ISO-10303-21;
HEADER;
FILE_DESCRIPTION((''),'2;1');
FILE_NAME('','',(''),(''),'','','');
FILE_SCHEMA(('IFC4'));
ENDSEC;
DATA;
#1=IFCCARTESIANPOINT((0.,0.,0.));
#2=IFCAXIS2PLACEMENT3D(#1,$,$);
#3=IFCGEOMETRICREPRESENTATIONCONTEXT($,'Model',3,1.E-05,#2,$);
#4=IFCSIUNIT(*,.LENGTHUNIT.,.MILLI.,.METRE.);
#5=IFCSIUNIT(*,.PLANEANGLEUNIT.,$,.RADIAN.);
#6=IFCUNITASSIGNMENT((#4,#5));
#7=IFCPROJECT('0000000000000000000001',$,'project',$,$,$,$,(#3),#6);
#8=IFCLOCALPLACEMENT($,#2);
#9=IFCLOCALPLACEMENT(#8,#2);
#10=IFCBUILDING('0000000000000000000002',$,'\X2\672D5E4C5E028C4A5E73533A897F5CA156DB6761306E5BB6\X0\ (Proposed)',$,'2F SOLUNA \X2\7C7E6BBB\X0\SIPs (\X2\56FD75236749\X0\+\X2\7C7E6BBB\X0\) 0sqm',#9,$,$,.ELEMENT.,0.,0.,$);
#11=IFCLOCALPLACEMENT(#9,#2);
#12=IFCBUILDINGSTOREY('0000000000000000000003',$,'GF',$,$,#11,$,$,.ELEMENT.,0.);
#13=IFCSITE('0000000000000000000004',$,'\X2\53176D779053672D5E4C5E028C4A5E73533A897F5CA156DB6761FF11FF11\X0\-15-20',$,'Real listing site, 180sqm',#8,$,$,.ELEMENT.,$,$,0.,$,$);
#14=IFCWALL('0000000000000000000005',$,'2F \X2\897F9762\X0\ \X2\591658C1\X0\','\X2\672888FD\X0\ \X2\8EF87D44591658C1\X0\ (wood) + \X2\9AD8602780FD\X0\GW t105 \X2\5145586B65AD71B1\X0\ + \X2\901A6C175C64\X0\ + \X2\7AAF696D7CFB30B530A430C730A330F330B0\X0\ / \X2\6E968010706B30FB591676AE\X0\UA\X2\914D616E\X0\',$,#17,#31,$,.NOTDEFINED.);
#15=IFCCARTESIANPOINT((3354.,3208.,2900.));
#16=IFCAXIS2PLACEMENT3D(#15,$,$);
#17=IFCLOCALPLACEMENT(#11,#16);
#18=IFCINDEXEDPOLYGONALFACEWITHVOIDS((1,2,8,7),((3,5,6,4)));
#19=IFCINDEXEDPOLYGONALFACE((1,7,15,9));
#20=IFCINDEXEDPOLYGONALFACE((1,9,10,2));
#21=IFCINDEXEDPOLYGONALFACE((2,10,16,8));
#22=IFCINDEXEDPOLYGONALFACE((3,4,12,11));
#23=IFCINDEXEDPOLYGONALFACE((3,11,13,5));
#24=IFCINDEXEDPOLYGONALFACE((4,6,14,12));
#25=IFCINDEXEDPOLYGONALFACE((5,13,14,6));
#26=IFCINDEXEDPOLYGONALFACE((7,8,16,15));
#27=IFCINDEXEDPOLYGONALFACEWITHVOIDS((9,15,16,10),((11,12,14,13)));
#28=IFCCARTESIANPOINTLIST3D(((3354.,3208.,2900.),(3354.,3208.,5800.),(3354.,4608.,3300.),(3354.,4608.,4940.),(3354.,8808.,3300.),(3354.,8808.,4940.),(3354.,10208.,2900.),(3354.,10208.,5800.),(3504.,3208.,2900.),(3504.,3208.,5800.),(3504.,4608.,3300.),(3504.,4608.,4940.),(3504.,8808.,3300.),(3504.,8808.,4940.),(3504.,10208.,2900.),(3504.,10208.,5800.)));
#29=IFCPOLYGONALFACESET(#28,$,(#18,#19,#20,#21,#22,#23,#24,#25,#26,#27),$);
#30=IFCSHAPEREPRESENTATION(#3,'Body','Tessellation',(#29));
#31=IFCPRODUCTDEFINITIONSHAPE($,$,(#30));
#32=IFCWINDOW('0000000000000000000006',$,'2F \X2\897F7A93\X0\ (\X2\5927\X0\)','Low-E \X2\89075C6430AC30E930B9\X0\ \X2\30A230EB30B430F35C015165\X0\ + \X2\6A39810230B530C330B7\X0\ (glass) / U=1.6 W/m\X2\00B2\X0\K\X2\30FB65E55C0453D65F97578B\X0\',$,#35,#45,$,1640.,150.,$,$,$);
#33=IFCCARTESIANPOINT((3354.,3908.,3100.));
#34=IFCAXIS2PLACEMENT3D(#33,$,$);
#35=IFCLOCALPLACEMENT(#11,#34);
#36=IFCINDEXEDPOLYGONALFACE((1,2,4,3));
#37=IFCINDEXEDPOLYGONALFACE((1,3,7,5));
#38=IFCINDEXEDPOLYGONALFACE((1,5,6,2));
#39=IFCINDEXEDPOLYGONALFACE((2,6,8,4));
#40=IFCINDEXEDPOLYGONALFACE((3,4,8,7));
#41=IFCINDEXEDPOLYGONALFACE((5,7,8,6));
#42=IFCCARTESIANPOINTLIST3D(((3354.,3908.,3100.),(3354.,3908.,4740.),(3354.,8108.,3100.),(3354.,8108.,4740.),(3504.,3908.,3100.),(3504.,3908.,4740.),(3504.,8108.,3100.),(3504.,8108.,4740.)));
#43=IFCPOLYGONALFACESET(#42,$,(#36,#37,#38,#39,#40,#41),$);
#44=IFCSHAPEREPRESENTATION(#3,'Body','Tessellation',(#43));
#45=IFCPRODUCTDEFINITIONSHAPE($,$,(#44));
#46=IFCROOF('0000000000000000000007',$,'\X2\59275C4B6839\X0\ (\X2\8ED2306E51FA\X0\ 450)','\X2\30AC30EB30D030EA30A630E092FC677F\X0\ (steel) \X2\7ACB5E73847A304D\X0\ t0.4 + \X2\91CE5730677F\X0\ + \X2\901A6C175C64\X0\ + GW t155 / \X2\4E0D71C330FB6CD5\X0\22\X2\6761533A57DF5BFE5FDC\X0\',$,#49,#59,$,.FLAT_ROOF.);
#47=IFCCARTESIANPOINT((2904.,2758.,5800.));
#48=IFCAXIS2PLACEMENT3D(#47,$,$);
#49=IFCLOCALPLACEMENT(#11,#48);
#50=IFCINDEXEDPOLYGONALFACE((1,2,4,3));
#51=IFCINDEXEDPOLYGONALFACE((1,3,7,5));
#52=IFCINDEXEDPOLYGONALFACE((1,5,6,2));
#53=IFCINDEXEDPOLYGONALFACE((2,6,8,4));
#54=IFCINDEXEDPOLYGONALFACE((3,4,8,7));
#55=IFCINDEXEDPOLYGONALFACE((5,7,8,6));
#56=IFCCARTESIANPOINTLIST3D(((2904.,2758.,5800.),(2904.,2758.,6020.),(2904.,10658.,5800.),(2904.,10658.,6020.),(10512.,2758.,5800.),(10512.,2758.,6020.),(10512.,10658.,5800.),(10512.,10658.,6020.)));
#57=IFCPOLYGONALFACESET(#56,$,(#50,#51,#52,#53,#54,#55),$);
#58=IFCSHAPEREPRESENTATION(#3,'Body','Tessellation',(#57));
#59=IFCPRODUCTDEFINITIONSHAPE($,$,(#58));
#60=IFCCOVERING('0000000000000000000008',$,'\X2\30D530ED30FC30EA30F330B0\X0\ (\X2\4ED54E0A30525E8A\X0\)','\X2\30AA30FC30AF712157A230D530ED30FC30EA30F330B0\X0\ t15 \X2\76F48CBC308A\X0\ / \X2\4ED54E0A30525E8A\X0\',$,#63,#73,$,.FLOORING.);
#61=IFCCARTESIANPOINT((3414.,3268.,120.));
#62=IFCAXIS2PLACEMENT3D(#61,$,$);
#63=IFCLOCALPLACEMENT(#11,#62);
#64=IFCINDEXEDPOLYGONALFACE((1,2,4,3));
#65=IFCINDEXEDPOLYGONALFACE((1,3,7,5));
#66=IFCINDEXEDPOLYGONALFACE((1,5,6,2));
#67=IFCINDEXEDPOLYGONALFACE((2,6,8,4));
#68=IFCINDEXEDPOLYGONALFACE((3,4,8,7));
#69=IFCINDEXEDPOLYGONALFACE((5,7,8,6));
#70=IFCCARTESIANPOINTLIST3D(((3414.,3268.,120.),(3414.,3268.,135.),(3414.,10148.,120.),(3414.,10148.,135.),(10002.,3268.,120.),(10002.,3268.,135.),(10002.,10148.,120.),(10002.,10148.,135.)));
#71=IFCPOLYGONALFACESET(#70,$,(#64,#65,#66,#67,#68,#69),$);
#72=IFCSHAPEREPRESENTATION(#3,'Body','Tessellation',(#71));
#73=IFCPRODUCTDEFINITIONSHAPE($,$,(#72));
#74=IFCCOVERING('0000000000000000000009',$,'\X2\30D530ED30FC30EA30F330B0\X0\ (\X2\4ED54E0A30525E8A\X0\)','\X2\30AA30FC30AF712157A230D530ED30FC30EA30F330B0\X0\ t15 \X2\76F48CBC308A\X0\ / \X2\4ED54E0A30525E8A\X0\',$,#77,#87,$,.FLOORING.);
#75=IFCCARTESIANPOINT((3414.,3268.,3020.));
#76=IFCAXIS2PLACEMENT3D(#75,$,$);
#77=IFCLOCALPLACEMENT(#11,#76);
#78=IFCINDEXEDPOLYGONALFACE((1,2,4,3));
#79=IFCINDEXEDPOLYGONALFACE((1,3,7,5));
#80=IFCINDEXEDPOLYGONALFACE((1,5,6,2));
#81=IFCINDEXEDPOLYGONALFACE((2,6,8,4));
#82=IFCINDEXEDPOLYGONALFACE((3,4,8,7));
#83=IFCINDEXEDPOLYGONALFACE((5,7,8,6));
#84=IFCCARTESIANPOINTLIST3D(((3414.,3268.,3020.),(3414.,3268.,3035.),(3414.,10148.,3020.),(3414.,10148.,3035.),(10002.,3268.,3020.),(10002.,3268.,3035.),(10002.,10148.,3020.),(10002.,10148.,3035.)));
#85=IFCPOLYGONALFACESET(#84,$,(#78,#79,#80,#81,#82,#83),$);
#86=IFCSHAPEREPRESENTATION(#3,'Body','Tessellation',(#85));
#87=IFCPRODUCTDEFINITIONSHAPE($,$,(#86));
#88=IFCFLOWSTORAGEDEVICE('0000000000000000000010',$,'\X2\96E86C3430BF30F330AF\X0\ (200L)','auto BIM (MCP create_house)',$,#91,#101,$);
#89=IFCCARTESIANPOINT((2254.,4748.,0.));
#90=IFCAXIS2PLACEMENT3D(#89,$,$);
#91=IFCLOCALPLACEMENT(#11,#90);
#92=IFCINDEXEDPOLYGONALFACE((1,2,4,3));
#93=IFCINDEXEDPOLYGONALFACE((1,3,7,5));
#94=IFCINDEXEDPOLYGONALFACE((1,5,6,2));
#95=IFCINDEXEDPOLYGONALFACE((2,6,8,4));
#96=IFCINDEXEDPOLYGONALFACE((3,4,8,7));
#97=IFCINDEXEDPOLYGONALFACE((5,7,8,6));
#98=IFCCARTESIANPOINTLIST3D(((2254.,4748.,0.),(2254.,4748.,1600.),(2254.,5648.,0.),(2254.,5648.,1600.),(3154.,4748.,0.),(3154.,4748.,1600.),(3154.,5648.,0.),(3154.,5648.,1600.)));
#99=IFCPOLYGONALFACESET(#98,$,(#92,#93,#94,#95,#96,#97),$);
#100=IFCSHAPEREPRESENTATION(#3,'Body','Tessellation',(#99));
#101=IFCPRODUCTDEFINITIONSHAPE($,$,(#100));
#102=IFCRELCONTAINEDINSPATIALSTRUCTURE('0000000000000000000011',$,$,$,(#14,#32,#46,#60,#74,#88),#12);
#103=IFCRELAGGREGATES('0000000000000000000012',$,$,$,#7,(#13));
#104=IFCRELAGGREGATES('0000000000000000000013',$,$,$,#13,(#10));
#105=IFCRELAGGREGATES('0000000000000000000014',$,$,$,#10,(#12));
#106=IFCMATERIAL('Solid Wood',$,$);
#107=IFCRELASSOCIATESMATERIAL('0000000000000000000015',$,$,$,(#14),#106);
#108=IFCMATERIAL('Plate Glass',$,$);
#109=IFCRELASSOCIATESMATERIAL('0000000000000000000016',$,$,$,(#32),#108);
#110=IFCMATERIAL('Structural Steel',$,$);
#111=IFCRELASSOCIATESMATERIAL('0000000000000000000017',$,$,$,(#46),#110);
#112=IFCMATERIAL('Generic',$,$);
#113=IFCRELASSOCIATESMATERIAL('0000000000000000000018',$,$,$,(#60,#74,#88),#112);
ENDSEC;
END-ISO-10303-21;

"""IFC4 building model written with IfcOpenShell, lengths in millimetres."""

from ifc_helpers import new_model, si_unit, frame, frame_2d, origin, place, context, project, spatial, rectangle, extrude, material, element, fill, save


model = new_model("IFC4")

# Units and contexts
model_context = context("Model", 3, precision=1e-05, world=origin())
ifc_project = project(units=[si_unit("LENGTHUNIT", "METRE", prefix="MILLI"), si_unit("PLANEANGLEUNIT", "RADIAN")], contexts=[model_context])

# Site, building, storey
site_placement = place(None, origin())
site = spatial("IfcSite", under=ifc_project, at=site_placement, Name="北海道札幌市豊平区西岡四条１１-15-20", ObjectType="Real listing site, 180sqm", CompositionType="ELEMENT", RefElevation=0.0)
building_placement = place(site_placement, origin())
building = spatial("IfcBuilding", under=site, at=building_placement, Name="札幌市豊平区西岡四条の家 (Proposed)", ObjectType="2F SOLUNA 籾殻SIPs (国産杉+籾殻) 0sqm", CompositionType="ELEMENT", ElevationOfRefHeight=0.0, ElevationOfTerrain=0.0)
storey_placement = place(building_placement, origin())
storey = spatial("IfcBuildingStorey", under=building, at=storey_placement, Name="GF", CompositionType="ELEMENT", Elevation=0.0)

# Shared definitions
ifc_material_1 = material(Name="Solid Wood")

# Shared definitions
ifc_material_2 = material(Name="Plate Glass")

# Wall, opening, window
wall_1_placement = place(storey_placement, frame((3354.0, 3208.0, 2900.0)))
wall_1 = element("IfcWall", 1, at=wall_1_placement, inside=storey, material=ifc_material_1, Name="2F 西面 外壁", Description="木製 軸組外壁 (wood) + 高性能GW t105 充填断熱 + 通気層 + 窯業系サイディング / 準耐火・外皮UA配慮", PredefinedType="NOTDEFINED", context=model_context, shape_type="SweptSolid", body=[
    extrude(rectangle(XDim=150.0, YDim=7000.0, at=frame_2d((75.0, 3500.0))), frame((3354.0, 3208.0, 2900.0)), (0.0, 0.0, 1.0), 2900.0),
])
opening_1_placement = place(storey_placement, frame((3354.0, 3908.0, 3100.0)))
opening_1 = element("IfcOpeningElement", 2, at=opening_1_placement, cuts=wall_1, PredefinedType="NOTDEFINED", context=model_context, shape_type="SweptSolid", body=[
    extrude(rectangle(XDim=150.0, YDim=4200.0, at=frame_2d((75.0, 2100.0))), frame((3354.0, 3908.0, 3100.0)), (0.0, 0.0, 1.0), 1640.0),
])
window_1_placement = place(storey_placement, frame((3354.0, 3908.0, 3100.0)))
window_1 = element("IfcWindow", 3, at=window_1_placement, inside=storey, material=ifc_material_2, Name="2F 西窓 (大)", Description="Low-E 複層ガラス アルゴン封入 + 樹脂サッシ (glass) / U=1.6 W/m²K・日射取得型", OverallHeight=1640.0, OverallWidth=150.0, context=model_context, shape_type="SweptSolid", body=[
    extrude(rectangle(XDim=150.0, YDim=4200.0, at=frame_2d((75.0, 2100.0))), frame((3354.0, 3908.0, 3100.0)), (0.0, 0.0, 1.0), 1640.0),
])
fill(opening_1, window_1)

# Roof
ifc_material_3 = material(Name="Structural Steel")
roof_placement = place(storey_placement, frame((2904.0, 2758.0, 5800.0)))
element("IfcRoof", 4, at=roof_placement, inside=storey, material=ifc_material_3, Name="大屋根 (軒の出 450)", Description="ガルバリウム鋼板 (steel) 立平葺き t0.4 + 野地板 + 通気層 + GW t155 / 不燃・法22条区域対応", PredefinedType="FLAT_ROOF", context=model_context, shape_type="SweptSolid", body=[
    extrude(rectangle(XDim=7608.0, YDim=7900.0, at=frame_2d((3804.0, 3950.0))), frame((2904.0, 2758.0, 5800.0)), (0.0, 0.0, 1.0), 220.0),
])

# Coverings
ifc_material_4 = material(Name="Generic")
covering_1_placement = place(storey_placement, frame((3414.0, 3268.0, 120.0)))
element("IfcCovering", 5, at=covering_1_placement, inside=storey, material=ifc_material_4, Name="フローリング (仕上げ床)", Description="オーク無垢フローリング t15 直貼り / 仕上げ床", PredefinedType="FLOORING", context=model_context, shape_type="SweptSolid", body=[
    extrude(rectangle(XDim=6588.0, YDim=6880.0, at=frame_2d((3294.0, 3440.0))), frame((3414.0, 3268.0, 120.0)), (0.0, 0.0, 1.0), 15.0),
])
covering_2_placement = place(storey_placement, frame((3414.0, 3268.0, 3020.0)))
element("IfcCovering", 6, at=covering_2_placement, inside=storey, material=ifc_material_4, Name="フローリング (仕上げ床)", Description="オーク無垢フローリング t15 直貼り / 仕上げ床", PredefinedType="FLOORING", context=model_context, shape_type="SweptSolid", body=[
    extrude(rectangle(XDim=6588.0, YDim=6880.0, at=frame_2d((3294.0, 3440.0))), frame((3414.0, 3268.0, 3020.0)), (0.0, 0.0, 1.0), 15.0),
])

# Flow storage device
flow_storage_device_placement = place(storey_placement, frame((2254.0, 4748.0, 0.0)))
element("IfcFlowStorageDevice", 7, at=flow_storage_device_placement, inside=storey, material=ifc_material_4, Name="雨水タンク (200L)", Description="auto BIM (MCP create_house)", context=model_context, shape_type="SweptSolid", body=[
    extrude(rectangle(XDim=900.0, YDim=900.0, at=frame_2d((450.0, 450.0))), frame((2254.0, 4748.0, 0.0)), (0.0, 0.0, 1.0), 1600.0),
])

save(model, "model.ifc")
